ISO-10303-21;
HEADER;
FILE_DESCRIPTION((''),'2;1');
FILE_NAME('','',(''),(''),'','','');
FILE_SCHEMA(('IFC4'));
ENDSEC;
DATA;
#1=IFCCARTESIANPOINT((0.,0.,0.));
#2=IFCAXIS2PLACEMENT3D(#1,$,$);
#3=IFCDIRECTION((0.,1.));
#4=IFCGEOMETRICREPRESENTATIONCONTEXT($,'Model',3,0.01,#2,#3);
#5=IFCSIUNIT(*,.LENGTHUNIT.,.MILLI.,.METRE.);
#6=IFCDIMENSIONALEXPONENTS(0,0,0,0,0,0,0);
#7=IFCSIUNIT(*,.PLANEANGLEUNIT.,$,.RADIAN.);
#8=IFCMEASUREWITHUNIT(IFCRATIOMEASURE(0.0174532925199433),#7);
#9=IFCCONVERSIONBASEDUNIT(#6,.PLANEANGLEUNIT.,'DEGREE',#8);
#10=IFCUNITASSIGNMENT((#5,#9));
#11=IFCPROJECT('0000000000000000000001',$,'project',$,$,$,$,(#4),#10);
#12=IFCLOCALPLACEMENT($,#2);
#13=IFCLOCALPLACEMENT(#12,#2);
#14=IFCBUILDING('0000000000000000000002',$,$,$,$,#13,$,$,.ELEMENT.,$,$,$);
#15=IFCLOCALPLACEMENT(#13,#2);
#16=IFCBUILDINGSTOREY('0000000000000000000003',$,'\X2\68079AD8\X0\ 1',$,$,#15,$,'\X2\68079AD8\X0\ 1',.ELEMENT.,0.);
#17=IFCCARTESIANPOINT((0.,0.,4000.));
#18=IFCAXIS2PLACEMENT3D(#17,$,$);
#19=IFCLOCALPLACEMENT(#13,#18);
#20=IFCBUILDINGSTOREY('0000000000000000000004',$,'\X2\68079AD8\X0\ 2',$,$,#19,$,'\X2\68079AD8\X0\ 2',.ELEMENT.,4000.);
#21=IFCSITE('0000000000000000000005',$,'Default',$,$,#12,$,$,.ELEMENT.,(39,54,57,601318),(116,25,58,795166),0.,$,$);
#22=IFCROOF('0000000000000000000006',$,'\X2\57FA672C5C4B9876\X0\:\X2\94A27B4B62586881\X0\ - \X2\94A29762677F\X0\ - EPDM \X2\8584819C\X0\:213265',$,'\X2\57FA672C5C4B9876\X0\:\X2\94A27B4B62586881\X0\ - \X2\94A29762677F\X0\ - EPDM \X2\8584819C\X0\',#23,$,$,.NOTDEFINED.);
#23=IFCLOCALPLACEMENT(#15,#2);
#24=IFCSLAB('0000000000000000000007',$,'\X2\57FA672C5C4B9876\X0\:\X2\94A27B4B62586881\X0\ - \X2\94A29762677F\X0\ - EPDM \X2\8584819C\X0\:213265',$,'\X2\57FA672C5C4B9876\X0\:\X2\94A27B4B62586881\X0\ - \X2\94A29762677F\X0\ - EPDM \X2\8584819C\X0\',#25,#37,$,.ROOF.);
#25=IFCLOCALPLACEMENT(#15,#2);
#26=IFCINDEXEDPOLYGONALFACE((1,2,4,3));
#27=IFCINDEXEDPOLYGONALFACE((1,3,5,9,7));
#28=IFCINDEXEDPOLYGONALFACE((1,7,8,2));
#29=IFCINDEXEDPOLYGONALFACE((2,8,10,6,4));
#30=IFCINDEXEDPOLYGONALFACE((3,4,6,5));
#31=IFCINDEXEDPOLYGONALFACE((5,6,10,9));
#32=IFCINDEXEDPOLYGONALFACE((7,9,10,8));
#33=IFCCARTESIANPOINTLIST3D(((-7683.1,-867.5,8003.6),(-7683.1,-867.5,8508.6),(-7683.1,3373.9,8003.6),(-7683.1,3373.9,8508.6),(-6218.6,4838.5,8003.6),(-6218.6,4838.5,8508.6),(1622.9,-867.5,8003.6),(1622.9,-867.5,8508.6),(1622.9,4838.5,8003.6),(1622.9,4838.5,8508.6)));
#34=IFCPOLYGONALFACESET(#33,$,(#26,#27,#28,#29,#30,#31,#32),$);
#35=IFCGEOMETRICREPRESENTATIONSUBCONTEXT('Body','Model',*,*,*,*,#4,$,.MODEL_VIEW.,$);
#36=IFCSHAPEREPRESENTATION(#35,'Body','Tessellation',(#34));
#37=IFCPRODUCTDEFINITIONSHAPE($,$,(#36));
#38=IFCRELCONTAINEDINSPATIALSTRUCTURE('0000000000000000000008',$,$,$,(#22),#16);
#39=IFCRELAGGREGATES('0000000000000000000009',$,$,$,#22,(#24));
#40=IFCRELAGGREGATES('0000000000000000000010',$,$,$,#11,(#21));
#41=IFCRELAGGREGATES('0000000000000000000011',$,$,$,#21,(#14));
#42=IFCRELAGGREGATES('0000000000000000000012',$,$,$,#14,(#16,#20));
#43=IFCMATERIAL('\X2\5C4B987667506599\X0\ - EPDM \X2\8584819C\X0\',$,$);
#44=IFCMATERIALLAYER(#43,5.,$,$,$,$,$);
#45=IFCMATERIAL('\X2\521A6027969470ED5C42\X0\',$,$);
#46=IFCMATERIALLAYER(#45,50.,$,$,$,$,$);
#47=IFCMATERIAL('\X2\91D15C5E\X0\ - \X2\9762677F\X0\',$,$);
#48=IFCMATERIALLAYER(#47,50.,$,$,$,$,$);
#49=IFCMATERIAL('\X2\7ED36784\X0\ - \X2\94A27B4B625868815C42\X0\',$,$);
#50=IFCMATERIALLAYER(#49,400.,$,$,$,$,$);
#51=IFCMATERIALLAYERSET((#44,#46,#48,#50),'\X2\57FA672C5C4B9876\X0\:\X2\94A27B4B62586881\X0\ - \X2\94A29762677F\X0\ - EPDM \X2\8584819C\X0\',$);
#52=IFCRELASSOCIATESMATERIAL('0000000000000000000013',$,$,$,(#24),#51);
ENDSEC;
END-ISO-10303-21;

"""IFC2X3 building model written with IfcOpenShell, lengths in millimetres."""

from ifc_helpers import new_model, entity, si_unit, converted_unit, direction, frame, origin, place, context, subcontext, project, spatial, polyline, outline, extrude, material, layer, layer_set, element, aggregate, save


model = new_model("IFC2X3")

# Units and contexts
model_context = context("Model", 3, precision=0.01, world=origin(), true_north=direction((0.0, 1.0)))
body_context = subcontext(model_context, "Body", "Model", "MODEL_VIEW")
ifc_project = project(units=[si_unit("LENGTHUNIT", "METRE", prefix="MILLI"), converted_unit("PLANEANGLEUNIT", "DEGREE", entity("IfcRatioMeasure", 0.0174532925199433), si_unit("PLANEANGLEUNIT", "RADIAN"), dimensions=[0, 0, 0, 0, 0, 0, 0])], contexts=[model_context])

# Site, building, storey
site_placement = place(None, origin())
site = spatial("IfcSite", under=ifc_project, at=site_placement, Name="Default", CompositionType="ELEMENT", RefLatitude=(39, 54, 57, 601318), RefLongitude=(116, 25, 58, 795166), RefElevation=0.0)
building_placement = place(site_placement, origin())
building = spatial("IfcBuilding", under=site, at=building_placement, CompositionType="ELEMENT")
storey_1_placement = place(building_placement, origin())
storey_1 = spatial("IfcBuildingStorey", under=building, at=storey_1_placement, Name="标高 1", LongName="标高 1", CompositionType="ELEMENT", Elevation=0.0)

# Roof, slab
roof_placement = place(storey_1_placement, frame((-7683.1, -867.5, 8003.6)))
roof = element("IfcRoof", 1, at=roof_placement, inside=storey_1, Name="基本屋顶:钢筋托梁 - 钢面板 - EPDM 薄膜:213265", ObjectType="基本屋顶:钢筋托梁 - 钢面板 - EPDM 薄膜", ShapeType="NOTDEFINED")
ifc_material_1 = material(Name="屋顶材料 - EPDM 薄膜")
ifc_layer_1 = layer(ifc_material_1, 5.0)
ifc_material_2 = material(Name="刚性隔热层")
ifc_layer_2 = layer(ifc_material_2, 50.0)
ifc_material_3 = material(Name="金属 - 面板")
ifc_layer_3 = layer(ifc_material_3, 50.0)
ifc_material_4 = material(Name="结构 - 钢筋托梁层")
ifc_layer_4 = layer(ifc_material_4, 400.0)
ifc_layer_set_1 = layer_set([ifc_layer_1, ifc_layer_2, ifc_layer_3, ifc_layer_4], Name="基本屋顶:钢筋托梁 - 钢面板 - EPDM 薄膜")
slab_1_placement = place(roof_placement, origin())
slab_1 = element("IfcSlab", 2, at=slab_1_placement, material=ifc_layer_set_1, Name="基本屋顶:钢筋托梁 - 钢面板 - EPDM 薄膜:213265", ObjectType="基本屋顶:钢筋托梁 - 钢面板 - EPDM 薄膜", PredefinedType="ROOF", context=body_context, shape_type="SweptSolid", body=[
    extrude(outline(polyline([(-4653.0, 1388.4), (-4653.0, -2853.0), (4653.0, -2853.0), (4653.0, 2853.0), (-3188.4, 2853.0), (-4653.0, 1388.4)])), frame((4653.0, 2853.0, 0.0)), (0.0, 0.0, 1.0), 505.0),
])
aggregate(roof, [slab_1])

# Shared definitions
storey_2_placement = place(building_placement, frame((0.0, 0.0, 4000.0)))
storey_2 = spatial("IfcBuildingStorey", under=building, at=storey_2_placement, Name="标高 2", LongName="标高 2", CompositionType="ELEMENT", Elevation=4000.0)

save(model, "model.ifc")
